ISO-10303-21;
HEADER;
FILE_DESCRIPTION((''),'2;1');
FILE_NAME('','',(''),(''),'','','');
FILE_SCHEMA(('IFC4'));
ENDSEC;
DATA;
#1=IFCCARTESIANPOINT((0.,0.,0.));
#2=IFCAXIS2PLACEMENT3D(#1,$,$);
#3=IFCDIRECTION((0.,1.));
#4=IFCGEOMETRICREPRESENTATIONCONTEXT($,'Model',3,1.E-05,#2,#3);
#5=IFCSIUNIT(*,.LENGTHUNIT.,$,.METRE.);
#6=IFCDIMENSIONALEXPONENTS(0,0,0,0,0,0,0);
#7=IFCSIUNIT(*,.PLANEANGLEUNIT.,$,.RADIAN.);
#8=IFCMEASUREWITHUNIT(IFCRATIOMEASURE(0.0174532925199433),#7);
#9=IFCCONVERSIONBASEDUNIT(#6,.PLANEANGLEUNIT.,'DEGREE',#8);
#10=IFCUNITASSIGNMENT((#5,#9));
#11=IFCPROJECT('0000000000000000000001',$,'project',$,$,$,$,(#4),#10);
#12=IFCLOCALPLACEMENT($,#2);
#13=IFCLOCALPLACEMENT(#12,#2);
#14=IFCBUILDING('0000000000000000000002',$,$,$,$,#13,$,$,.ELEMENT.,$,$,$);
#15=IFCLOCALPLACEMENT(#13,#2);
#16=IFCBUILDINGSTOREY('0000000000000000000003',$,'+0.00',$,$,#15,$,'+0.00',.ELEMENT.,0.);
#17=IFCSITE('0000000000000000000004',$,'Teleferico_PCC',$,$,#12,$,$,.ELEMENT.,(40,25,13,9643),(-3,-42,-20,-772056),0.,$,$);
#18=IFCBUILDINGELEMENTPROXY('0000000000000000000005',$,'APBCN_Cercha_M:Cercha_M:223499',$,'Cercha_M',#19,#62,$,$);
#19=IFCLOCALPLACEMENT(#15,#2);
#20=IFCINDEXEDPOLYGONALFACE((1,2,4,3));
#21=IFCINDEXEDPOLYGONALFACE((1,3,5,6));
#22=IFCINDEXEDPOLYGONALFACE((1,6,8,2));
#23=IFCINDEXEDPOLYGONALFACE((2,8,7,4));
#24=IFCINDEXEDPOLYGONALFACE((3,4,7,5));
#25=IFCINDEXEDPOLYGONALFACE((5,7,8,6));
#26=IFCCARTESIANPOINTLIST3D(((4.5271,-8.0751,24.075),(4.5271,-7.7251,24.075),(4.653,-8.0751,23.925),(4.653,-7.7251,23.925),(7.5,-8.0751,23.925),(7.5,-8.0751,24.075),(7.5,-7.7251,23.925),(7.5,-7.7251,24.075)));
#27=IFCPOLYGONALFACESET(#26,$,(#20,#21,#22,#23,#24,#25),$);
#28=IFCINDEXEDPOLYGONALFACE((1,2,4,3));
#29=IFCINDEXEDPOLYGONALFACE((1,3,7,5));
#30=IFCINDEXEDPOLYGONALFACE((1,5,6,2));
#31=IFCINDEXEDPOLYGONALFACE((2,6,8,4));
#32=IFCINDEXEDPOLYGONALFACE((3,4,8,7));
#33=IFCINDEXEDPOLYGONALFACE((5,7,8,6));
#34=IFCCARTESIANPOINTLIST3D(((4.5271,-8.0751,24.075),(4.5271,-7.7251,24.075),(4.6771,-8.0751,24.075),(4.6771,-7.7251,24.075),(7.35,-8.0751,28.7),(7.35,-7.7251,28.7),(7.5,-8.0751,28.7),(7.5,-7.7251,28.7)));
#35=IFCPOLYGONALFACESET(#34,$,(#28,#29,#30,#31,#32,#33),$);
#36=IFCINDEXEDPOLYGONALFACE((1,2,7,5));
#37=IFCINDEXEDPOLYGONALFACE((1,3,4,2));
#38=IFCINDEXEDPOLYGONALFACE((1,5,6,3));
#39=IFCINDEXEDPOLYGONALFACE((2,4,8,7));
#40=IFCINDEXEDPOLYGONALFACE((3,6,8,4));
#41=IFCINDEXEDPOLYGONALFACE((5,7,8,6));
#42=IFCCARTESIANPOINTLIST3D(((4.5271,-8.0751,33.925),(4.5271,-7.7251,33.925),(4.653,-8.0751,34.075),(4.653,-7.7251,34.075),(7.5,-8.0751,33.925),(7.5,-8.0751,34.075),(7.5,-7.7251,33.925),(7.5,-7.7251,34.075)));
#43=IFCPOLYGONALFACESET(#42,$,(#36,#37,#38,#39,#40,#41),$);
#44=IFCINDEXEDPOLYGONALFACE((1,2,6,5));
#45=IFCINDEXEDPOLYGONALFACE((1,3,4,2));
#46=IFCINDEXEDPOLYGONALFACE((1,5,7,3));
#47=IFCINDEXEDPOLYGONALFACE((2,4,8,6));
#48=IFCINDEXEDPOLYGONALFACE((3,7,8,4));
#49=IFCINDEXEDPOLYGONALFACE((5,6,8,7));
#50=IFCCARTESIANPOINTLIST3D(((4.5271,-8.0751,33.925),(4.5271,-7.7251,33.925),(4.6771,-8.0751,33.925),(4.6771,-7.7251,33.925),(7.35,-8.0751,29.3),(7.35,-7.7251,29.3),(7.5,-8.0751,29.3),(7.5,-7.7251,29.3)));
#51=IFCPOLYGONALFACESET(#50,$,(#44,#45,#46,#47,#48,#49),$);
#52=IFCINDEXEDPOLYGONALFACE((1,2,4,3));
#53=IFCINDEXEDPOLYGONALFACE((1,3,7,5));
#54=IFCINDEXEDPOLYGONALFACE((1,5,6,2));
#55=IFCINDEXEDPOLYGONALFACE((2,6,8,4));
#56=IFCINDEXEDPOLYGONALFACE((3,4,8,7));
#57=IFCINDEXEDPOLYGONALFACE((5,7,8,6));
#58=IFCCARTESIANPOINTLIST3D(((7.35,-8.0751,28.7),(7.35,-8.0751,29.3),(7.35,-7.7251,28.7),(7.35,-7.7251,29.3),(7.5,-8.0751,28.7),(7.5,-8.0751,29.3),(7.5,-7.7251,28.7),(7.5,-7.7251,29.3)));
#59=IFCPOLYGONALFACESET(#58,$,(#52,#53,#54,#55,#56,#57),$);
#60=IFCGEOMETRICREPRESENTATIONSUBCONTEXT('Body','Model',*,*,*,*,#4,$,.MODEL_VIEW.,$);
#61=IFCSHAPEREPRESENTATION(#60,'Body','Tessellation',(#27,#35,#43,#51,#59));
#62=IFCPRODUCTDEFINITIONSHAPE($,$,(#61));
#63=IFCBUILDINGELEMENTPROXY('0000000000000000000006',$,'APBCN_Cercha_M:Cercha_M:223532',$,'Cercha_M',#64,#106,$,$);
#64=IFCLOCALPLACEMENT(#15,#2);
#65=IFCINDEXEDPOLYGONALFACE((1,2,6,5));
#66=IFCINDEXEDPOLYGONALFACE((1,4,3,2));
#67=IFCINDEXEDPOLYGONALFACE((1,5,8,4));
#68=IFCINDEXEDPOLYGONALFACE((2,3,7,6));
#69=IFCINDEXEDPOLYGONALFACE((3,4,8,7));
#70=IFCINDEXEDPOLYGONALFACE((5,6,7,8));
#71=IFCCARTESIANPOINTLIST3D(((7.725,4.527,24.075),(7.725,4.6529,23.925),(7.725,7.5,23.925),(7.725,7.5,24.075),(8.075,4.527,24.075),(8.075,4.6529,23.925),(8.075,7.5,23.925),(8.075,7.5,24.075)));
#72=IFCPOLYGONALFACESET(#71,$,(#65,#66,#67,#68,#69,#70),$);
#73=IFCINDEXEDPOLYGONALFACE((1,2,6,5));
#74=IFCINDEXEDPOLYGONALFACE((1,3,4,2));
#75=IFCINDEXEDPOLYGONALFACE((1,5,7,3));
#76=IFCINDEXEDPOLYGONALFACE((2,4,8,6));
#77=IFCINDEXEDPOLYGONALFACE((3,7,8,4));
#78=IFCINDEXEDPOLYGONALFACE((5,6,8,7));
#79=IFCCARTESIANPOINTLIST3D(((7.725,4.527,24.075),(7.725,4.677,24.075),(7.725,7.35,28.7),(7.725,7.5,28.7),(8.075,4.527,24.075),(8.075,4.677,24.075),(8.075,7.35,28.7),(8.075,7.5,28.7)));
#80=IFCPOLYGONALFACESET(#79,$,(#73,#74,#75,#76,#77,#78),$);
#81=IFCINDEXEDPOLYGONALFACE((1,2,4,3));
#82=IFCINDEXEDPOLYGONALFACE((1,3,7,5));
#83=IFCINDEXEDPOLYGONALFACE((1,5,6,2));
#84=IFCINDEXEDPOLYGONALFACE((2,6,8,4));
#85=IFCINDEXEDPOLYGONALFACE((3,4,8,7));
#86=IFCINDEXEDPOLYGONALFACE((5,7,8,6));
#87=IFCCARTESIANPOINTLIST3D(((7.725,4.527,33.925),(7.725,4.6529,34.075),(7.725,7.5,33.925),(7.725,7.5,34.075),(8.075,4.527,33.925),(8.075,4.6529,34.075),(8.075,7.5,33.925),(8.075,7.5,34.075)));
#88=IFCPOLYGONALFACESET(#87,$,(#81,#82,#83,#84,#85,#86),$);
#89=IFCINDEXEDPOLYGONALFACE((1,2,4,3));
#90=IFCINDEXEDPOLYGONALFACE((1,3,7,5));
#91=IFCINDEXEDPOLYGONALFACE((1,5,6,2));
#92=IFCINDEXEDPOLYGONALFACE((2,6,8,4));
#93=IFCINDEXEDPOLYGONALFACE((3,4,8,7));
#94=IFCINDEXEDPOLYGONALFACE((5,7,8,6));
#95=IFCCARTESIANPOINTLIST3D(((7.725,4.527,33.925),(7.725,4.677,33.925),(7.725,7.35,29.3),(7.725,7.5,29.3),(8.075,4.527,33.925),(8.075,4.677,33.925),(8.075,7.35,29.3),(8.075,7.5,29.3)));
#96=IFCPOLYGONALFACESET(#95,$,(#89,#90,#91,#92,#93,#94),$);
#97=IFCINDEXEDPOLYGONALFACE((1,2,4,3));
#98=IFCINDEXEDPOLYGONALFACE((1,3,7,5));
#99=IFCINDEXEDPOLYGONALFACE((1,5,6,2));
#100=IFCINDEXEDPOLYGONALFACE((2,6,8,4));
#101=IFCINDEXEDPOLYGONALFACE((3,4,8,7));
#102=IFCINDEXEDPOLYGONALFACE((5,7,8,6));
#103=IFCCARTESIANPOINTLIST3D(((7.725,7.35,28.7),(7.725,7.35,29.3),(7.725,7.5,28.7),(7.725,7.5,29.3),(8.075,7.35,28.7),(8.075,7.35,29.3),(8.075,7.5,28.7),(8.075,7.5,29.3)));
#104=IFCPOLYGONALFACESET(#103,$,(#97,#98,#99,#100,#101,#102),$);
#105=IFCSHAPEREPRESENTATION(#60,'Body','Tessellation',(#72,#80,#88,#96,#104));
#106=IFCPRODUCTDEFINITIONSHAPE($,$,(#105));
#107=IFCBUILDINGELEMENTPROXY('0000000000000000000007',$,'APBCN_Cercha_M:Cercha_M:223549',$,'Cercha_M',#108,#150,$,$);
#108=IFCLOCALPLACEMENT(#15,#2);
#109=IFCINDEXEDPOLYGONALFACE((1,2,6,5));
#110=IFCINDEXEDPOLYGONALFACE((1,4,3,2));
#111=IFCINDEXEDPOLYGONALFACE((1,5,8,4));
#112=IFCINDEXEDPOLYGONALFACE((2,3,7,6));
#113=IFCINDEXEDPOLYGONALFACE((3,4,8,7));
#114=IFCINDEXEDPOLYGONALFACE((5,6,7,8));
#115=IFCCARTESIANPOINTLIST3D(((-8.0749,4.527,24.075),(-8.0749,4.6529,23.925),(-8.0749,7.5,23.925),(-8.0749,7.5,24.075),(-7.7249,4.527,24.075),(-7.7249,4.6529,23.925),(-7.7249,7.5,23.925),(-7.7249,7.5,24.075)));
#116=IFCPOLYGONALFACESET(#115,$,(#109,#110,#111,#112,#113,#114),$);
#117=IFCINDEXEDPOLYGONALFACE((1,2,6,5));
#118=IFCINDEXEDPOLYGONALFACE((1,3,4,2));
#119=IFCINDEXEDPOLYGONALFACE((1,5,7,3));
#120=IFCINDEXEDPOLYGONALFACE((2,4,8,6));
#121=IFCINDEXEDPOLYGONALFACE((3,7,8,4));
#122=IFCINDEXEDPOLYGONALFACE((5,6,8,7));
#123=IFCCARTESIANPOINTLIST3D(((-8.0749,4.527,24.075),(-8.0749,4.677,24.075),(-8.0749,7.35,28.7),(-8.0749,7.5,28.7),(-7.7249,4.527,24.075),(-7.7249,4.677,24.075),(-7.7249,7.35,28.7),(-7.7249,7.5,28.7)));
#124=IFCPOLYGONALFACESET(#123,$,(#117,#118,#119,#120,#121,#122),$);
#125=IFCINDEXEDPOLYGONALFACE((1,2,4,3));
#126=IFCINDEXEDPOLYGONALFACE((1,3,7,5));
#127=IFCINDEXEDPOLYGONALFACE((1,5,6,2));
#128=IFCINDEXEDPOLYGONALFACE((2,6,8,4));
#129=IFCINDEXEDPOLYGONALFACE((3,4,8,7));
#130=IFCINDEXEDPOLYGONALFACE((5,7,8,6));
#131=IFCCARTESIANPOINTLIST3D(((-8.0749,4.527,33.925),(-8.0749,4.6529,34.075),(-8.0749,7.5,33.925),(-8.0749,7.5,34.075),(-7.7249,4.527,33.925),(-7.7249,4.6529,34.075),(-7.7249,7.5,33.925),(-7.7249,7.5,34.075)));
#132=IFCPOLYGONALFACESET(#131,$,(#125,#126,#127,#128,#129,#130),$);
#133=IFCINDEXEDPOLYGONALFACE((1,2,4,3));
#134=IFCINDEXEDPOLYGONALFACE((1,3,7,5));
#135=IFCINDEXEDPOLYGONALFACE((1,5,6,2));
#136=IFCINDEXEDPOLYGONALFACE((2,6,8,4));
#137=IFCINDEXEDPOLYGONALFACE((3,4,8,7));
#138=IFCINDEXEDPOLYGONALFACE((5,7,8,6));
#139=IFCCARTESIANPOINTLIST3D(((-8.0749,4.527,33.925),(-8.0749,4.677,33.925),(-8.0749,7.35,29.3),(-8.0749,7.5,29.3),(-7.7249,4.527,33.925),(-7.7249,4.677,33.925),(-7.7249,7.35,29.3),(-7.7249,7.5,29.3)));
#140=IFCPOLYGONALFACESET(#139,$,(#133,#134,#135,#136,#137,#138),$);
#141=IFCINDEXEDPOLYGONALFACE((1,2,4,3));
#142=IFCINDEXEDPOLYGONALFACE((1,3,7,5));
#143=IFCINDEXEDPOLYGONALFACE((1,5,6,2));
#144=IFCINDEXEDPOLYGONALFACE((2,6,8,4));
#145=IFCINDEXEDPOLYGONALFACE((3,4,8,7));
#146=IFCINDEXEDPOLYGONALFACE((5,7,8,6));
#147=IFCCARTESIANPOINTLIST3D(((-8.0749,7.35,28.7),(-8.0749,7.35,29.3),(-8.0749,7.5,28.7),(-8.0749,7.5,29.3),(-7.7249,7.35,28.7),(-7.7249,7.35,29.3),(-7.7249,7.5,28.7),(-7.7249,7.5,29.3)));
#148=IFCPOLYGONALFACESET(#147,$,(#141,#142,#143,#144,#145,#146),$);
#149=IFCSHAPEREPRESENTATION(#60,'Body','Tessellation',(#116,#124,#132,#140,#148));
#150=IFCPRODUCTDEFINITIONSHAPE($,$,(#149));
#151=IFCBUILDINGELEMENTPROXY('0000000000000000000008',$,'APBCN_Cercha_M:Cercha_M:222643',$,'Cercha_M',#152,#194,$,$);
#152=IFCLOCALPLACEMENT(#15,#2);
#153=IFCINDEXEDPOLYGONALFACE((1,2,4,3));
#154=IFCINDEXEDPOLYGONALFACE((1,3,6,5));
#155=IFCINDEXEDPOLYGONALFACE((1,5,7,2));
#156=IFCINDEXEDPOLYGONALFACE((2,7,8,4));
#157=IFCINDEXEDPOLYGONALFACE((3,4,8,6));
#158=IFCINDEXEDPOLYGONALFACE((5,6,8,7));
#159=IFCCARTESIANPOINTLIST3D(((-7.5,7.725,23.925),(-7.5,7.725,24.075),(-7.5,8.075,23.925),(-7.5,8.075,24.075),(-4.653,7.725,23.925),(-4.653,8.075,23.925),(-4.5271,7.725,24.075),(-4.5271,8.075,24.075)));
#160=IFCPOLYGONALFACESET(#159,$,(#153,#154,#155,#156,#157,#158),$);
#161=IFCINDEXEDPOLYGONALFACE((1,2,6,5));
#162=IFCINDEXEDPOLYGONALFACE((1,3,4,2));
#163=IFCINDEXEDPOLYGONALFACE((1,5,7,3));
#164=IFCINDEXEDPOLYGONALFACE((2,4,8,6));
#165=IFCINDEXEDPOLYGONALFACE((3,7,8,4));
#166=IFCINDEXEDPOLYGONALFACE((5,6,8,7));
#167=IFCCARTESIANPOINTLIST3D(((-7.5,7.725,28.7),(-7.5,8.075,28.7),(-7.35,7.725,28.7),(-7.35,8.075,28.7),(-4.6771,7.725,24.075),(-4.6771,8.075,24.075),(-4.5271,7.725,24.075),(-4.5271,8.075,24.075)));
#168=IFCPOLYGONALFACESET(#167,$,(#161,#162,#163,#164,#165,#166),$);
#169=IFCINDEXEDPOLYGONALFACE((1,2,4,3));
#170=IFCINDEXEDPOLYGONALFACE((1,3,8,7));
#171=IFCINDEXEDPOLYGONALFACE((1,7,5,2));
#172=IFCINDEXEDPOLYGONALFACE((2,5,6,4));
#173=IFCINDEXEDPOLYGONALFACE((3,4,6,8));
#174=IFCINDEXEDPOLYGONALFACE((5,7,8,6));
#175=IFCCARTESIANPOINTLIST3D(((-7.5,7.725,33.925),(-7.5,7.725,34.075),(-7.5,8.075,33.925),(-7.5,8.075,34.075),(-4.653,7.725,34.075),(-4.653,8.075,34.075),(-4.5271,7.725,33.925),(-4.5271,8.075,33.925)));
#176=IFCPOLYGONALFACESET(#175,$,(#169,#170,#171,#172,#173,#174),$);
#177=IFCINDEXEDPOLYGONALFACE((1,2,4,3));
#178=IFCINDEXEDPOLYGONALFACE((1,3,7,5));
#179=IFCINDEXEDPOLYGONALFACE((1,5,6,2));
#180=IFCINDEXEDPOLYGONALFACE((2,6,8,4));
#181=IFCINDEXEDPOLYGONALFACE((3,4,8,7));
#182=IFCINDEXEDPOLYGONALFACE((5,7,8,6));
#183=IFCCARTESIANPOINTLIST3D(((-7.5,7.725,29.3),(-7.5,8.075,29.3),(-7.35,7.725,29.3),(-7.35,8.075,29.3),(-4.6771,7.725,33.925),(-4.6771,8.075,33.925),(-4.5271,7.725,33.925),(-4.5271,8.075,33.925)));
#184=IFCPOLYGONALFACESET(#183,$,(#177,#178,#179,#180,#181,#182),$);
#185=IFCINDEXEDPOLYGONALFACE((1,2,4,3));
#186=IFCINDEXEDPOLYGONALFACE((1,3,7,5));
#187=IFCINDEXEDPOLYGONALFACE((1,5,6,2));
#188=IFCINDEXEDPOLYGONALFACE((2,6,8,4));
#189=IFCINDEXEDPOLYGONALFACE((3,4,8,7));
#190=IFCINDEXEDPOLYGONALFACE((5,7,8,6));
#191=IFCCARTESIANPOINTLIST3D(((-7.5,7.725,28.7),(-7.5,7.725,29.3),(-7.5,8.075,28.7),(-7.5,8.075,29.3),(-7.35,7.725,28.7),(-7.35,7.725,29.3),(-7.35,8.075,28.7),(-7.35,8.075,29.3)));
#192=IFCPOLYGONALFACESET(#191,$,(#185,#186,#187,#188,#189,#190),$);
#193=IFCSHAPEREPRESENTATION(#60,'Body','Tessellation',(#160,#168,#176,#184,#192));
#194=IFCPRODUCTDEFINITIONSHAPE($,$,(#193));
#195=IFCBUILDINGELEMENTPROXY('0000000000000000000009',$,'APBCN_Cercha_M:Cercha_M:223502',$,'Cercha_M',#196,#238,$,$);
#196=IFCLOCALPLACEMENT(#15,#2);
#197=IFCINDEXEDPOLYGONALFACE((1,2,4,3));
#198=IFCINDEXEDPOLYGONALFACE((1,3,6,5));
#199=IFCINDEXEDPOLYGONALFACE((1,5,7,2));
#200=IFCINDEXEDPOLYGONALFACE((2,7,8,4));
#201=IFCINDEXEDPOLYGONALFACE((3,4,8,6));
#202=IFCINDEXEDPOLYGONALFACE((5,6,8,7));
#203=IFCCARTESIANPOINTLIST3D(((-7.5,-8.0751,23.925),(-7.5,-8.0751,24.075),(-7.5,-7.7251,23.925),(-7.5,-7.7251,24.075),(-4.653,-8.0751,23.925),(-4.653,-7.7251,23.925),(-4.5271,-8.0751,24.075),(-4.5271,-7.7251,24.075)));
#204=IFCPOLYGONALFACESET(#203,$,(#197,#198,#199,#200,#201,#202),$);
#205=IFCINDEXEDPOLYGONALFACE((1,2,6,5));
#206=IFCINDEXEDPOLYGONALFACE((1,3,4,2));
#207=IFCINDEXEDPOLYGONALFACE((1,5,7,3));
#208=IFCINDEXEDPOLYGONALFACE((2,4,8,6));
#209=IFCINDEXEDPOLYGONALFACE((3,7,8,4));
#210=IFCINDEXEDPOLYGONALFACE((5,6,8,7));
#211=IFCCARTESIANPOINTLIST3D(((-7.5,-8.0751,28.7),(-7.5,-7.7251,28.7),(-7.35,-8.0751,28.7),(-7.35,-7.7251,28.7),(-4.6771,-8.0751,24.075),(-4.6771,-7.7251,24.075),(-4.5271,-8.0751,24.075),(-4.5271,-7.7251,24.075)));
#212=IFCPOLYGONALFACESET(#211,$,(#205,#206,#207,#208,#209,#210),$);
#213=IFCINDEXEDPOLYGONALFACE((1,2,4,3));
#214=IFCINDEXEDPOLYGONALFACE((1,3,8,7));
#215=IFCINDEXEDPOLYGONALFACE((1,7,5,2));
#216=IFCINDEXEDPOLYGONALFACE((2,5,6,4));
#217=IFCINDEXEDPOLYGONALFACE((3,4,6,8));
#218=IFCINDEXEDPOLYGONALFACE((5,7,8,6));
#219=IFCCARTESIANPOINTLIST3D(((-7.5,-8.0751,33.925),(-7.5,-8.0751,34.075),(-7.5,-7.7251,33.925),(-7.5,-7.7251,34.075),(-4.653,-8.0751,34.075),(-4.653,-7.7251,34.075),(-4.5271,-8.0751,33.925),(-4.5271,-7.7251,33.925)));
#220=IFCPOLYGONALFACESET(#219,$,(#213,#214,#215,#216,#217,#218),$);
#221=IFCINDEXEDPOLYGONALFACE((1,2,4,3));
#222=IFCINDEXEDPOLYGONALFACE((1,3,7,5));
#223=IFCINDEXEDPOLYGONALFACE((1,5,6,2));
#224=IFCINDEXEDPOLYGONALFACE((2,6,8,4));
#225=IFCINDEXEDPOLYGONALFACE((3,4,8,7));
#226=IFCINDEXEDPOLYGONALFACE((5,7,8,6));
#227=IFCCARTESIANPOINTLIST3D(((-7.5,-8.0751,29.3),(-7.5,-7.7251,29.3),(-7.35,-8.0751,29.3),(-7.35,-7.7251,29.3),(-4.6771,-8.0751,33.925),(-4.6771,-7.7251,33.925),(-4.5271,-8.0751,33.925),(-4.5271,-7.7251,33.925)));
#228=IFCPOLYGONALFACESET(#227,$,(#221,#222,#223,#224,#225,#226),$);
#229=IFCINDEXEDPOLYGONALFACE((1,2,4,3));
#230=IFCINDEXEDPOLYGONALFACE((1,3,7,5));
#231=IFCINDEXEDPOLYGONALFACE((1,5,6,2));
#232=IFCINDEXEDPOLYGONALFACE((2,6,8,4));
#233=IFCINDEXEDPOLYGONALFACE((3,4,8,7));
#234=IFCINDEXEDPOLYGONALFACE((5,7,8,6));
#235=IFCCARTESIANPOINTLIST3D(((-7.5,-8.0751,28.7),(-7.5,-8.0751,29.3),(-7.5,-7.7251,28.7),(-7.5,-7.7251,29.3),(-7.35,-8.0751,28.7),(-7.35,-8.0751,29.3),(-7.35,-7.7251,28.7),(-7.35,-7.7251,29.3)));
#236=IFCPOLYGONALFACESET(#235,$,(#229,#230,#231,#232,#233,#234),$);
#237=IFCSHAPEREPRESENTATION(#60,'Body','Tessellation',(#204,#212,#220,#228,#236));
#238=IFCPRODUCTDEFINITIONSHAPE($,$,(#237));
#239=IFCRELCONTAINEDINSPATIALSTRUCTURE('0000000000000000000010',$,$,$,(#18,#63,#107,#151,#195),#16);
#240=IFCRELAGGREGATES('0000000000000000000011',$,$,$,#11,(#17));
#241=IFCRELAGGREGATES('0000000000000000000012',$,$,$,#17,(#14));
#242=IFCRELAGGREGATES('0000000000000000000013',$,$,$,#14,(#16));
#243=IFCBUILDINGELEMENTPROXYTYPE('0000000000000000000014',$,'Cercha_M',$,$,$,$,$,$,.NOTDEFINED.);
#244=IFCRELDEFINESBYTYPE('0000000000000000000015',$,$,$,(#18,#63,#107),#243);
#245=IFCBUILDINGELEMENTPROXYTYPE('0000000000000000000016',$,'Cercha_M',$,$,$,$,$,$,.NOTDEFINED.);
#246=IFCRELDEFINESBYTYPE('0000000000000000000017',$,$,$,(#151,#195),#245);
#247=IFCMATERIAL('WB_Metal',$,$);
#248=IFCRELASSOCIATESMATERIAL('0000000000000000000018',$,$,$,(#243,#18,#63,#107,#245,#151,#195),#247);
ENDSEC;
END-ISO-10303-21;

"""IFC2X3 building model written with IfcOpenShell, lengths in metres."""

from ifc_helpers import new_model, entity, si_unit, converted_unit, direction, frame, origin, origin_2d_with_axis, place, context, subcontext, project, spatial, polyline, rectangle, outline, extrude, source, transform, mapped, material, type_object, type_shapes, element, save


model = new_model("IFC2X3")

# Units and contexts
model_context = context("Model", 3, precision=1e-05, world=origin(), true_north=direction((0.0, 1.0)))
body_context = subcontext(model_context, "Body", "Model", "MODEL_VIEW")
ifc_project = project(units=[si_unit("LENGTHUNIT", "METRE"), converted_unit("PLANEANGLEUNIT", "DEGREE", entity("IfcRatioMeasure", 0.0174532925199433), si_unit("PLANEANGLEUNIT", "RADIAN"), dimensions=[0, 0, 0, 0, 0, 0, 0])], contexts=[model_context])

# Site, building, storey
site_placement = place(None, origin())
site = spatial("IfcSite", under=ifc_project, at=site_placement, Name="Teleferico_PCC", CompositionType="ELEMENT", RefLatitude=(40, 25, 13, 9643), RefLongitude=(-3, -42, -20, -772056), RefElevation=0.0)
building_placement = place(site_placement, origin())
building = spatial("IfcBuilding", under=site, at=building_placement, CompositionType="ELEMENT")
storey_placement = place(building_placement, origin())
storey = spatial("IfcBuildingStorey", under=building, at=storey_placement, Name="+0.00", LongName="+0.00", CompositionType="ELEMENT", Elevation=0.0)

# Shared definitions
ifc_material = material(Name="WB_Metal")

# Building element proxies
building_element_proxy_type_1 = type_object("IfcBuildingElementProxyType", Name="Cercha_M", PredefinedType="NOTDEFINED", material=ifc_material)
shared_shape_1 = source(origin(), body_context, "Body", "SweptSolid", [
    extrude(outline(polyline([(-1.455, -0.075), (1.3921, -0.075), (1.5179, 0.075), (-1.455, 0.075), (-1.455, -0.075)])), frame((-1.455, -0.175, -5.0), z_axis=(0.0, 1.0, 0.0), x_axis=(-1.0, 0.0, 0.0)), (0.0, 0.0, 1.0), 0.35),
    extrude(outline(polyline([(1.3365, -2.3125), (1.4865, -2.3125), (-1.3365, 2.3125), (-1.4865, 2.3125), (1.3365, -2.3125)])), frame((-1.4865, -0.175, -2.6125), z_axis=(0.0, 1.0, 0.0), x_axis=(1.0, 0.0, 0.0)), (0.0, 0.0, 1.0), 0.35),
    extrude(outline(polyline([(-1.455, -0.075), (1.5179, -0.075), (1.3921, 0.075), (-1.455, 0.075), (-1.455, -0.075)])), frame((-1.455, -0.175, 5.0), z_axis=(0.0, 1.0, 0.0), x_axis=(-1.0, 0.0, 0.0)), (0.0, 0.0, 1.0), 0.35),
    extrude(outline(polyline([(-2.6701, -0.064), (2.7483, -0.064), (2.6701, 0.064), (-2.7483, 0.064), (-2.6701, -0.064)])), frame((-1.4865, -0.175, 2.6125), z_axis=(0.0, 1.0, 0.0), x_axis=(-0.520985, 0.0, 0.853566)), (0.0, 0.0, 1.0), 0.35),
    extrude(rectangle(XDim=0.35, YDim=0.15, at=origin_2d_with_axis()), frame((-0.075, 0.0, -0.3), z_axis=(0.0, 0.0, 1.0), x_axis=(0.0, 1.0, 0.0)), (0.0, 0.0, 1.0), 0.6),
])
type_shapes(building_element_proxy_type_1, [shared_shape_1])
for number, where, name in (
    (1, (7.5, -7.9001, 29.0), "APBCN_Cercha_M:Cercha_M:223499"),
):
    element("IfcBuildingElementProxy", number, at=place(storey_placement, frame(where)), inside=storey, type_object=building_element_proxy_type_1, material=ifc_material, Name=name, ObjectType="Cercha_M", context=body_context, shape_type="MappedRepresentation", body=[
        mapped(shared_shape_1, transform((0.0, 0.0, 0.0), scale=1.0)),
    ])
for number, where, z_axis, x_axis, name in (
    (2, (7.9, 7.5, 29.0), (0.0, 0.0, 1.0), (0.0, 1.0, 0.0), "APBCN_Cercha_M:Cercha_M:223532"),
    (3, (-7.8999, 7.5, 29.0), (0.0, 0.0, 1.0), (0.0, 1.0, 0.0), "APBCN_Cercha_M:Cercha_M:223549"),
):
    element("IfcBuildingElementProxy", number, at=place(storey_placement, frame(where, z_axis=z_axis, x_axis=x_axis)), inside=storey, type_object=building_element_proxy_type_1, material=ifc_material, Name=name, ObjectType="Cercha_M", context=body_context, shape_type="MappedRepresentation", body=[
        mapped(shared_shape_1, transform((0.0, 0.0, 0.0), scale=1.0)),
    ])
building_element_proxy_type_2 = type_object("IfcBuildingElementProxyType", Name="Cercha_M", PredefinedType="NOTDEFINED", material=ifc_material)
shared_shape_2 = source(origin(), body_context, "Body", "SweptSolid", [
    extrude(outline(polyline([(-0.075, -1.455), (0.075, -1.455), (0.075, 1.3921), (-0.075, 1.5179), (-0.075, -1.455)])), frame((-1.455, -0.175, -5.0), z_axis=(0.0, 1.0, 0.0), x_axis=(0.0, 0.0, -1.0)), (0.0, 0.0, 1.0), 0.35),
    extrude(outline(polyline([(1.3365, -2.3125), (1.4865, -2.3125), (-1.3365, 2.3125), (-1.4865, 2.3125), (1.3365, -2.3125)])), frame((-1.4865, -0.175, -2.6125), z_axis=(0.0, 1.0, 0.0), x_axis=(1.0, 0.0, 0.0)), (0.0, 0.0, 1.0), 0.35),
    extrude(outline(polyline([(-0.075, -1.455), (0.075, -1.455), (0.075, 1.5179), (-0.075, 1.3921), (-0.075, -1.455)])), frame((-1.455, -0.175, 5.0), z_axis=(0.0, 1.0, 0.0), x_axis=(0.0, 0.0, -1.0)), (0.0, 0.0, 1.0), 0.35),
    extrude(outline(polyline([(-2.6701, -0.064), (2.7483, -0.064), (2.6701, 0.064), (-2.7483, 0.064), (-2.6701, -0.064)])), frame((-1.4865, -0.175, 2.6125), z_axis=(0.0, 1.0, 0.0), x_axis=(-0.520985, 0.0, 0.853566)), (0.0, 0.0, 1.0), 0.35),
    extrude(rectangle(XDim=0.15, YDim=0.35, at=origin_2d_with_axis()), frame((-0.075, 0.0, -0.3), z_axis=(0.0, 0.0, 1.0), x_axis=(-1.0, 0.0, 0.0)), (0.0, 0.0, 1.0), 0.6),
])
type_shapes(building_element_proxy_type_2, [shared_shape_2])
for number, where, z_axis, x_axis, name in (
    (4, (-7.5, 7.9, 29.0), (0.0, 0.0, 1.0), (-1.0, 0.0, 0.0), "APBCN_Cercha_M:Cercha_M:222643"),
    (5, (-7.5, -7.9001, 29.0), (0.0, 0.0, 1.0), (-1.0, 0.0, 0.0), "APBCN_Cercha_M:Cercha_M:223502"),
):
    element("IfcBuildingElementProxy", number, at=place(storey_placement, frame(where, z_axis=z_axis, x_axis=x_axis)), inside=storey, type_object=building_element_proxy_type_2, material=ifc_material, Name=name, ObjectType="Cercha_M", context=body_context, shape_type="MappedRepresentation", body=[
        mapped(shared_shape_2, transform((0.0, 0.0, 0.0), scale=1.0)),
    ])

save(model, "model.ifc")
